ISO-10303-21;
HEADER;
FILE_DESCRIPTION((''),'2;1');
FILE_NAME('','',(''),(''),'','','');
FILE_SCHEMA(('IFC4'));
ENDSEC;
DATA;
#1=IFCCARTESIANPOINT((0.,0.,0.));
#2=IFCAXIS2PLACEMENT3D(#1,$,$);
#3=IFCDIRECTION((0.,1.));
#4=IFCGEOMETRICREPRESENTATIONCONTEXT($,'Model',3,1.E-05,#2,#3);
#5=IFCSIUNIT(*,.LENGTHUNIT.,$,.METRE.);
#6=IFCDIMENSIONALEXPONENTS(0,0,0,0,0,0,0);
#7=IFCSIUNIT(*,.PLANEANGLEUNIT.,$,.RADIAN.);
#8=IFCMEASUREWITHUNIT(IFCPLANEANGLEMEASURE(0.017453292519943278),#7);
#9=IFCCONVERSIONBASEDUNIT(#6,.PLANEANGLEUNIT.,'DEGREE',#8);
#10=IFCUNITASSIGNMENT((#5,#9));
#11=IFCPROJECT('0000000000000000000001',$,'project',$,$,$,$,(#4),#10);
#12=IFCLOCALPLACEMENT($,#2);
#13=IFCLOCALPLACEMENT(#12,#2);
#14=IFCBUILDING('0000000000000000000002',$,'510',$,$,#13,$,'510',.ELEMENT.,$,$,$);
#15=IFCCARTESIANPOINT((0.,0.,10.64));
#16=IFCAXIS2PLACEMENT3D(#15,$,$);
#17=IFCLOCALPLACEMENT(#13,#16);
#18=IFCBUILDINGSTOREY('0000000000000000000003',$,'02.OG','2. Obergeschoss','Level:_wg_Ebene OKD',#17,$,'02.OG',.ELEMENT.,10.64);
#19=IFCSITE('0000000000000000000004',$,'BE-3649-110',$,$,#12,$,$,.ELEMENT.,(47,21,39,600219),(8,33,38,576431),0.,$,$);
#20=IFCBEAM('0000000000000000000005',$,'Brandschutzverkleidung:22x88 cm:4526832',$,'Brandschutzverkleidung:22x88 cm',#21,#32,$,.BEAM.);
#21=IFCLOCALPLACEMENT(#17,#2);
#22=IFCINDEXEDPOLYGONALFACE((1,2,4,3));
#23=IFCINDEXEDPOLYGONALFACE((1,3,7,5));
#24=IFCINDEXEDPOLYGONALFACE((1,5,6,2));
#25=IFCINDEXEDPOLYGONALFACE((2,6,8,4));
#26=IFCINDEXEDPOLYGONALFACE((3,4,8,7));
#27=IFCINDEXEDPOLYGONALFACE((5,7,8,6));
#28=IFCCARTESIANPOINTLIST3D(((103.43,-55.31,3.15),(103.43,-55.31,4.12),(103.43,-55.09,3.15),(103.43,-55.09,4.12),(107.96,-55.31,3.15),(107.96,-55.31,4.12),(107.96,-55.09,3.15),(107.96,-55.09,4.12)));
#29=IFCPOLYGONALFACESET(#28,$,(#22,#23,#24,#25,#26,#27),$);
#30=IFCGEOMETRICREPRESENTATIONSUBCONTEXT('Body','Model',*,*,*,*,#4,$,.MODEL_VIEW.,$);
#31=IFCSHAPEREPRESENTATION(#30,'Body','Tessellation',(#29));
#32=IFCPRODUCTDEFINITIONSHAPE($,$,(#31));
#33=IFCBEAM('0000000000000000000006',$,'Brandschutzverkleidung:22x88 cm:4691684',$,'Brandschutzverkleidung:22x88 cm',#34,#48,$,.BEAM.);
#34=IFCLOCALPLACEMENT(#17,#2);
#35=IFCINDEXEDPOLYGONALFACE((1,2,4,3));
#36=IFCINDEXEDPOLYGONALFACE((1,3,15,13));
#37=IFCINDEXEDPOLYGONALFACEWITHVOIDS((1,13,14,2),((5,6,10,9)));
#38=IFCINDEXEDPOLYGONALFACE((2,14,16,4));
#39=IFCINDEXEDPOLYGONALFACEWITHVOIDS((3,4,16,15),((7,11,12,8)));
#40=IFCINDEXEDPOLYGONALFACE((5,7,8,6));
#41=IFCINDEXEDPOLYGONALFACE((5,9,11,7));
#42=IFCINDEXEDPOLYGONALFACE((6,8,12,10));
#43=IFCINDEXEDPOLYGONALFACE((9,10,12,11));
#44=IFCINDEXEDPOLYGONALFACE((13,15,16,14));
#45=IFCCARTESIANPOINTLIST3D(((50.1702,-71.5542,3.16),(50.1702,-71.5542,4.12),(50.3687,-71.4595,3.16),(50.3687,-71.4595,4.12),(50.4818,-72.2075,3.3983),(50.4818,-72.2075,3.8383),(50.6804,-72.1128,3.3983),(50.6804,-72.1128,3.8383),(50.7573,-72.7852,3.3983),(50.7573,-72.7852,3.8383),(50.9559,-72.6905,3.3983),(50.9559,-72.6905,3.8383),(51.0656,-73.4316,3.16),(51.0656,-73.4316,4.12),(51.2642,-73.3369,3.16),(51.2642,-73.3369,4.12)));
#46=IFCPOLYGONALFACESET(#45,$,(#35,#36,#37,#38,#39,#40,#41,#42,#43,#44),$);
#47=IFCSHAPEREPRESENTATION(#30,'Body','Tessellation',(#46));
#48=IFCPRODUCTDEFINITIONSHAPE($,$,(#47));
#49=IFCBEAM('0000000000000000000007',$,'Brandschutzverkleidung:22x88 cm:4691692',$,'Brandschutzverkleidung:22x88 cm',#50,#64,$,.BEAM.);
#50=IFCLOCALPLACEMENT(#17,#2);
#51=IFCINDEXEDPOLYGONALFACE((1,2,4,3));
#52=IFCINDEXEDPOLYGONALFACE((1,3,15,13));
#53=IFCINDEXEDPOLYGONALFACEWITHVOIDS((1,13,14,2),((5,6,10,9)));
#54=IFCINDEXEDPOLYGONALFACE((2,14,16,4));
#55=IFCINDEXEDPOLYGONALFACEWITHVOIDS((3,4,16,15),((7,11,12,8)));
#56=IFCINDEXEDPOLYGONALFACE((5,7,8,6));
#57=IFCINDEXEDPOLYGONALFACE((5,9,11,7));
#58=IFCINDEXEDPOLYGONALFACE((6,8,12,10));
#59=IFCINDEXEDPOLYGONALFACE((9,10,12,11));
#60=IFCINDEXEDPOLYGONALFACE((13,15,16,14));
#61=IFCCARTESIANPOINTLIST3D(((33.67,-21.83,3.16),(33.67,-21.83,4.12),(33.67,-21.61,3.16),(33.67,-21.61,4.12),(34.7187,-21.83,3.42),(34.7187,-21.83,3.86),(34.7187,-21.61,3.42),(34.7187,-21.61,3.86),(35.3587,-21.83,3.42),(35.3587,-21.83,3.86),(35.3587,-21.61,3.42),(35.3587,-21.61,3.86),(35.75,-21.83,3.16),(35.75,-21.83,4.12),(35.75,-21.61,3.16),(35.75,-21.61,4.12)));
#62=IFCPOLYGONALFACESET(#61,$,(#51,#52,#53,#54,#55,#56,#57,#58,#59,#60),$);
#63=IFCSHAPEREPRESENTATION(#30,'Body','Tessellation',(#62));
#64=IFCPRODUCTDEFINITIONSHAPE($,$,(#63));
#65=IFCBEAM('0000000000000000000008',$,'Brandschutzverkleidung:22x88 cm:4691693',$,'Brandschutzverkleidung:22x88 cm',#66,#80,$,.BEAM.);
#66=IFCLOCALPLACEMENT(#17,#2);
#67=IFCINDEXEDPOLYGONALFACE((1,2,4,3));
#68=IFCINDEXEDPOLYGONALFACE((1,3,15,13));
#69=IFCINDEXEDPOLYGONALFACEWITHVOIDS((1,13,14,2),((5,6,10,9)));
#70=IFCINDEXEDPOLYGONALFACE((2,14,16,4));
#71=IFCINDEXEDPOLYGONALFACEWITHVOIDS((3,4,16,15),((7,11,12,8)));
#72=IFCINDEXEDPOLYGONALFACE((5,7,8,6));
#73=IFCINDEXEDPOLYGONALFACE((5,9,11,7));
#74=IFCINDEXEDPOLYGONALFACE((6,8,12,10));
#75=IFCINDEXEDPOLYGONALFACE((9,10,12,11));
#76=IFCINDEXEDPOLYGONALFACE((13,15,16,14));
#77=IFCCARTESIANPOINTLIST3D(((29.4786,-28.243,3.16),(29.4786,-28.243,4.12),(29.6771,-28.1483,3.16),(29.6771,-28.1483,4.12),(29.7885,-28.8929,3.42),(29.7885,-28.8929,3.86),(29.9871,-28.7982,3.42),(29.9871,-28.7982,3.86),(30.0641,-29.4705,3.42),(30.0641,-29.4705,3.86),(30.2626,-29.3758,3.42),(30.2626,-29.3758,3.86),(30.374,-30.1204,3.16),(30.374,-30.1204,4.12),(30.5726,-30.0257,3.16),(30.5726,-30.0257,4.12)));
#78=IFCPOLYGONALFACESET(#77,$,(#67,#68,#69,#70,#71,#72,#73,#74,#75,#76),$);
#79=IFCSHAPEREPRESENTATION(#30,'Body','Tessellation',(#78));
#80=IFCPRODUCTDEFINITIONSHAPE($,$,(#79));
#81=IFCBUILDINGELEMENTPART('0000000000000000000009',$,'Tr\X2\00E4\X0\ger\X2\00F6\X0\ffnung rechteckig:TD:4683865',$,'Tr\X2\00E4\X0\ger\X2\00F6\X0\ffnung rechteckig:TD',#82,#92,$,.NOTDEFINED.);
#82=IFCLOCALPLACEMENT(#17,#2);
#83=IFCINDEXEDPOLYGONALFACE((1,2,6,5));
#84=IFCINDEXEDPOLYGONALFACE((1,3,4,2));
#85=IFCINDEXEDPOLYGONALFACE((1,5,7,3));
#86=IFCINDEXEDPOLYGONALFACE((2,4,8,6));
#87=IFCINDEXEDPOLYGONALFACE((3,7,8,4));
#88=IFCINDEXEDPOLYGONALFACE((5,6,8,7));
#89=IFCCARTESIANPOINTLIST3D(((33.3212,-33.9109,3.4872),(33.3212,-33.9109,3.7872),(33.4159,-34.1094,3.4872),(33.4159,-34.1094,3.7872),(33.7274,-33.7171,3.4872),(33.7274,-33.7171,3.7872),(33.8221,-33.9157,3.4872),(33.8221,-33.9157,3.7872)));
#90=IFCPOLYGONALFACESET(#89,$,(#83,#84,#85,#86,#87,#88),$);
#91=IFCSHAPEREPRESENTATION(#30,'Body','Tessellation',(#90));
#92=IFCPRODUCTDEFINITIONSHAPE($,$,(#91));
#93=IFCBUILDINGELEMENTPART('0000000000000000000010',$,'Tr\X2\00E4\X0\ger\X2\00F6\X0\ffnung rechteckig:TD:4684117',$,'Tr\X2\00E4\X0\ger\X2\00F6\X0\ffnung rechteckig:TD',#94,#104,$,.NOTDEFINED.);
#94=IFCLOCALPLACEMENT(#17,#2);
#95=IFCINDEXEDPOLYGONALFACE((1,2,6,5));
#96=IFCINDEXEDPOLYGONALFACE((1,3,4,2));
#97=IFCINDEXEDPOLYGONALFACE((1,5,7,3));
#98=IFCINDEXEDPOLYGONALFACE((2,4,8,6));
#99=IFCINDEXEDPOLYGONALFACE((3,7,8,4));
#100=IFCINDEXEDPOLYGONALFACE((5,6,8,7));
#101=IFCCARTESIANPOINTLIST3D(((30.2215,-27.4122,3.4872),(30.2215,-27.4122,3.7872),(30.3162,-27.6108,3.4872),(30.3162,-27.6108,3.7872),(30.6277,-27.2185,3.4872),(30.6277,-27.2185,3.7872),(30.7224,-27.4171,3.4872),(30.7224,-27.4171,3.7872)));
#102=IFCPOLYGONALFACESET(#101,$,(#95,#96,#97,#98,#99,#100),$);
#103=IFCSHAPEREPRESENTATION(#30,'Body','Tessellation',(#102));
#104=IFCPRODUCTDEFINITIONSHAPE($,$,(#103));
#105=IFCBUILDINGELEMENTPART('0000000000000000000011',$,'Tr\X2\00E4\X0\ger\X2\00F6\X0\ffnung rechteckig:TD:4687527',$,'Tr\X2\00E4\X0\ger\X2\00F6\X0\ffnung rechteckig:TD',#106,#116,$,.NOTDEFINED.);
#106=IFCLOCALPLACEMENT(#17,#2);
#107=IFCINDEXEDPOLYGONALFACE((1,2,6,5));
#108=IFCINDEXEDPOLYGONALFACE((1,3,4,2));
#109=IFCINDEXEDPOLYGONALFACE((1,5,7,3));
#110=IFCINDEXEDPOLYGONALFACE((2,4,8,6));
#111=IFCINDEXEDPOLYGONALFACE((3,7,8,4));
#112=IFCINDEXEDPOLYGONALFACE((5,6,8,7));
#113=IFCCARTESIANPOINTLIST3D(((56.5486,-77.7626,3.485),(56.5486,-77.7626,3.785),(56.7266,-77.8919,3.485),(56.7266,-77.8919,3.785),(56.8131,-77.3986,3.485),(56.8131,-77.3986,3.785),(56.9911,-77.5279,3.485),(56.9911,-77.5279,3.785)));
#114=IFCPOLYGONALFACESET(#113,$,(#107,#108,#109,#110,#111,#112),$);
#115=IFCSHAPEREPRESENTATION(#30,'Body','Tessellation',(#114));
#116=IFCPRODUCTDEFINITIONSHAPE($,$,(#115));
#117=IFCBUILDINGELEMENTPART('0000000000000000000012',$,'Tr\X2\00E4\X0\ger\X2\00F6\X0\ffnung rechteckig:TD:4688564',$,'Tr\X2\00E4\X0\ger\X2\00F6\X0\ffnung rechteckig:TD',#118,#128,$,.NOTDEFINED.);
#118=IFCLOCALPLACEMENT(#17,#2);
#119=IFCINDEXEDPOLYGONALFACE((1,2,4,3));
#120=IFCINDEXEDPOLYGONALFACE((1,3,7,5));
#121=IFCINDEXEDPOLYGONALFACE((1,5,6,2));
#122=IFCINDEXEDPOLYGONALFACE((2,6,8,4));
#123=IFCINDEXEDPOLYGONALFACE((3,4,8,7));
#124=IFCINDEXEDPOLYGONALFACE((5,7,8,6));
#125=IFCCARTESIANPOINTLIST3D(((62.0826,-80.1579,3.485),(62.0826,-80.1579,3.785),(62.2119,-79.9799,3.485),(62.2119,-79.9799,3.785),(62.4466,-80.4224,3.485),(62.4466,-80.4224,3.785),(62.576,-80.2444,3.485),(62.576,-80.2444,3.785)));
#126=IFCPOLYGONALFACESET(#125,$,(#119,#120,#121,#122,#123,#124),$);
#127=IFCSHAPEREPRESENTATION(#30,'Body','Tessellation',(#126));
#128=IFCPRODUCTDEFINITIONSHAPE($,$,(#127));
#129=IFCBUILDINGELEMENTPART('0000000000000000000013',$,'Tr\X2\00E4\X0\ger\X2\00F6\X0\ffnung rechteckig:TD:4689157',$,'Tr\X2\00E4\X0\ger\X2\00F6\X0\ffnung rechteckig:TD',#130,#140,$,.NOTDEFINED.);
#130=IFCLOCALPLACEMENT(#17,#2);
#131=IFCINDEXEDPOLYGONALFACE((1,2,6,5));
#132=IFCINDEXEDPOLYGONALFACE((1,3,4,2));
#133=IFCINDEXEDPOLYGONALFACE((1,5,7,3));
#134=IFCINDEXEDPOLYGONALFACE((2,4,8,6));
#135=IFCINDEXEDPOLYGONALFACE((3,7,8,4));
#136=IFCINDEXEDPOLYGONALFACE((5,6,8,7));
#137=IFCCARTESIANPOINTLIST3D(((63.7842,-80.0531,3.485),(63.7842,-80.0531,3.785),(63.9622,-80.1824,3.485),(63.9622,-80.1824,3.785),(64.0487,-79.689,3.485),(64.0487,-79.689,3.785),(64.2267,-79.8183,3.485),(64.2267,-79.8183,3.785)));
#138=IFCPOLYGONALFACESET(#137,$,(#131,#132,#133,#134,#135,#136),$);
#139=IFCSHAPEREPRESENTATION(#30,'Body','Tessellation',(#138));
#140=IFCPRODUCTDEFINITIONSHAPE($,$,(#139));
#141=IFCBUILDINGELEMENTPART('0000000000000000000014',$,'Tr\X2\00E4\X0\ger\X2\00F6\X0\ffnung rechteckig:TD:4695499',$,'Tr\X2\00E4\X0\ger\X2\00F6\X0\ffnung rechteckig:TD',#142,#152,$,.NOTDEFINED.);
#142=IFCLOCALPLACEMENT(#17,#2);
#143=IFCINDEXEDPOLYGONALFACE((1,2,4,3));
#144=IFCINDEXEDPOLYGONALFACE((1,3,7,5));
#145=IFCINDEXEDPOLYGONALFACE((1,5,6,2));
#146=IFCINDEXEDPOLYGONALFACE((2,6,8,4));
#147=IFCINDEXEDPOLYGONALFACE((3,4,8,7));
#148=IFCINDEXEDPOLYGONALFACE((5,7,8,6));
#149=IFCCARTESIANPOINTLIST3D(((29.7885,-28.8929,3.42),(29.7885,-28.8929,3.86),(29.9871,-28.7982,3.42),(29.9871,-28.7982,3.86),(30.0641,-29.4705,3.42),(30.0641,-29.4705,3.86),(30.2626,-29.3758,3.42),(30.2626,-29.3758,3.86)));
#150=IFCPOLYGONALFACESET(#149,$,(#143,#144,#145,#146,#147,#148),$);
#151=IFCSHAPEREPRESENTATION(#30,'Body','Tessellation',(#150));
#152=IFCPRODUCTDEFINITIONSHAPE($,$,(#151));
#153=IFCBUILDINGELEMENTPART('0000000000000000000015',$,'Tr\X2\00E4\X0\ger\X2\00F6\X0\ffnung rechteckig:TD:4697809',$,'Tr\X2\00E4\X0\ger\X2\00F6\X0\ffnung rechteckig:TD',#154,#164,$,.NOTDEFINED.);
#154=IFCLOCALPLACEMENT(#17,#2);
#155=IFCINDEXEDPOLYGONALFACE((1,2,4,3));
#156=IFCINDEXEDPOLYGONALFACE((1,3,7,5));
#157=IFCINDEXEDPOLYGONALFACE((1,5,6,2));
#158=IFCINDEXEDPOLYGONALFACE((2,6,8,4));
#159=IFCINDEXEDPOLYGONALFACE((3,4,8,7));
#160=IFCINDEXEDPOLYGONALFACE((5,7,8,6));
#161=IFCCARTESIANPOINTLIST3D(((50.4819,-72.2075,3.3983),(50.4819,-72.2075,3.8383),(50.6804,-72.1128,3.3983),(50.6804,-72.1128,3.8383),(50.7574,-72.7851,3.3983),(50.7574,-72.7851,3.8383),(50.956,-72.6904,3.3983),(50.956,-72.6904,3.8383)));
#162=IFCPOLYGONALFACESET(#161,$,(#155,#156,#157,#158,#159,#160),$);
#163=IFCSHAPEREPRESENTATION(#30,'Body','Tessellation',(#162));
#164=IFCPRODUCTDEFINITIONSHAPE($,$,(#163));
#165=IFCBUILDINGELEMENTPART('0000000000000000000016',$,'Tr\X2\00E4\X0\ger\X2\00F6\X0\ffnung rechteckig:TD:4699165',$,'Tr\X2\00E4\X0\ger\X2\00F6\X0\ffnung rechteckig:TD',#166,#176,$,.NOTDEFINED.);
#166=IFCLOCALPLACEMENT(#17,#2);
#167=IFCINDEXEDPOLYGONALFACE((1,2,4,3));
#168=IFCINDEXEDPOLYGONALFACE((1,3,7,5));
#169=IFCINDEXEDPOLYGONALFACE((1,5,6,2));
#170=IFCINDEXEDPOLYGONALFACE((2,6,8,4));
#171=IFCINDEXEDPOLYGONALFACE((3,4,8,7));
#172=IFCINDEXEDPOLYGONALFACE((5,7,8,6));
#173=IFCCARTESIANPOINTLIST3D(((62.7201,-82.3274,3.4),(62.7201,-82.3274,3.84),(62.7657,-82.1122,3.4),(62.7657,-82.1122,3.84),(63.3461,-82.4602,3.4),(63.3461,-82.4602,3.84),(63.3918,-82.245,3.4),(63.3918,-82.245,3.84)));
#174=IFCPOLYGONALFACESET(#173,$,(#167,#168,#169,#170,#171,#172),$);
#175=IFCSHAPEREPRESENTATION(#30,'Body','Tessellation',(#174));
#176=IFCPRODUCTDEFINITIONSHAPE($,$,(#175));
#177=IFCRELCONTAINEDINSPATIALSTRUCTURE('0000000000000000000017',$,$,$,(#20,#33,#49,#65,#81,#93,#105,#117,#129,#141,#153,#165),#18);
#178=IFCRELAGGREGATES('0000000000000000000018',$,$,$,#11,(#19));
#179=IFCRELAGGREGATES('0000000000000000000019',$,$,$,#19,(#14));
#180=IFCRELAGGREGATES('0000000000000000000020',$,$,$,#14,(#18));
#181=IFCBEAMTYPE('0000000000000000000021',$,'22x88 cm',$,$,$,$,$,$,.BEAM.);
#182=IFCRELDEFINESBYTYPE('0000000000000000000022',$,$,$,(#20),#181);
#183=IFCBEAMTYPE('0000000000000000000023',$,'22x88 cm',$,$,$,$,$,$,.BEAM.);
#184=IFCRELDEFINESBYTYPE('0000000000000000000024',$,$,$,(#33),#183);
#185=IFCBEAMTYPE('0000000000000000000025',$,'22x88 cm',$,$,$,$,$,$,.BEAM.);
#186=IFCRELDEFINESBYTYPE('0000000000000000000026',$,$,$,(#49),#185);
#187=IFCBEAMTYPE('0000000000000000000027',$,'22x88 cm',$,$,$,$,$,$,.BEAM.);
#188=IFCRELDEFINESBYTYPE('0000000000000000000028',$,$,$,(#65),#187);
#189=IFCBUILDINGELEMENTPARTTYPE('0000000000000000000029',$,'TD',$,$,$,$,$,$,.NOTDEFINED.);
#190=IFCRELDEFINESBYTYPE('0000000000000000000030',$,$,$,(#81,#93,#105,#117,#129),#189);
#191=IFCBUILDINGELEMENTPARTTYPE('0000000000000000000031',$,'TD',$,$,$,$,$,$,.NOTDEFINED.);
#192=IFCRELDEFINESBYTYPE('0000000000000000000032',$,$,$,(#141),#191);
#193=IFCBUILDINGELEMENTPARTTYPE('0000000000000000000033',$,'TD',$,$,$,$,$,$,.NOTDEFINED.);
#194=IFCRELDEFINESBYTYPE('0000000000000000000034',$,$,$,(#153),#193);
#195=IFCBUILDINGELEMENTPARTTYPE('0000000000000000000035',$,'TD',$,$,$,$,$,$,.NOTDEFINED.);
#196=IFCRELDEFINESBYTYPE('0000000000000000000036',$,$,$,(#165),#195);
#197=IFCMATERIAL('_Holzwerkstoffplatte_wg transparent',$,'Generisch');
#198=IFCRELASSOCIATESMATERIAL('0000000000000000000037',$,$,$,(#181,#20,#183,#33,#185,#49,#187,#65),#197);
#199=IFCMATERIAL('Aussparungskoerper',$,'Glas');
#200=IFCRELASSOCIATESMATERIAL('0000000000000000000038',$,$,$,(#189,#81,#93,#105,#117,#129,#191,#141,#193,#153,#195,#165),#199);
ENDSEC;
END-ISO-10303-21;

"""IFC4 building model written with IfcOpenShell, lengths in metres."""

from ifc_helpers import new_model, entity, si_unit, converted_unit, direction, frame, origin, place, context, subcontext, project, spatial, indexed_curve, outline, extrude, source, transform, mapped, material, type_object, type_shapes, element, save


model = new_model("IFC4")

# Units and contexts
model_context = context("Model", 3, precision=1e-05, world=origin(), true_north=direction((0.0, 1.0)))
body_context = subcontext(model_context, "Body", "Model", "MODEL_VIEW")
ifc_project = project(units=[si_unit("LENGTHUNIT", "METRE"), converted_unit("PLANEANGLEUNIT", "DEGREE", entity("IfcPlaneAngleMeasure", 0.017453292519943278), si_unit("PLANEANGLEUNIT", "RADIAN"), dimensions=[0, 0, 0, 0, 0, 0, 0])], contexts=[model_context])

# Site, building, storey
site_placement = place(None, origin())
site = spatial("IfcSite", under=ifc_project, at=site_placement, Name="BE-3649-110", CompositionType="ELEMENT", RefLatitude=(47, 21, 39, 600219), RefLongitude=(8, 33, 38, 576431), RefElevation=0.0)
building_placement = place(site_placement, origin())
building = spatial("IfcBuilding", under=site, at=building_placement, Name="510", LongName="510", CompositionType="ELEMENT")
storey_placement = place(building_placement, frame((0.0, 0.0, 10.64)))
storey = spatial("IfcBuildingStorey", under=building, at=storey_placement, Name="02.OG", Description="2. Obergeschoss", ObjectType="Level:_wg_Ebene OKD", LongName="02.OG", CompositionType="ELEMENT", Elevation=10.64)

# Shared definitions
ifc_material_1 = material(Name="_Holzwerkstoffplatte_wg transparent", Category="Generisch")

# Beam
beam_type_1 = type_object("IfcBeamType", Name="22x88 cm", PredefinedType="BEAM", material=ifc_material_1)
shared_shape_1 = source(origin(), body_context, "Body", "SweptSolid", [
    extrude(outline(indexed_curve([(-2.265, -0.11), (2.265, -0.11), (2.265, 0.11), (-2.265, 0.11), (-2.265, -0.11)], self_intersect=False)), frame((0.0, 0.0, -0.485)), (0.0, 0.0, 1.0), 0.97),
])
type_shapes(beam_type_1, [shared_shape_1])
beam_1_placement = place(storey_placement, frame((105.695, -55.2, 3.635)))
element("IfcBeam", 1, at=beam_1_placement, inside=storey, type_object=beam_type_1, material=ifc_material_1, Name="Brandschutzverkleidung:22x88 cm:4526832", ObjectType="Brandschutzverkleidung:22x88 cm", PredefinedType="BEAM", context=body_context, shape_type="MappedRepresentation", body=[
    mapped(shared_shape_1, transform((0.0, 0.0, 0.0), scale=1.0)),
])

# Beams
beam_type_2 = type_object("IfcBeamType", Name="22x88 cm", PredefinedType="BEAM", material=ifc_material_1)
shared_shape_2 = source(origin(), body_context, "Body", "SweptSolid", [
    extrude(outline(indexed_curve([(-1.04, -0.48), (1.04, -0.48), (1.04, 0.48), (-1.04, 0.48), (-1.04, -0.48)], self_intersect=False), holes=[indexed_curve([(0.3238, 0.2417), (0.3238, -0.1983), (-0.3162, -0.1983), (-0.3162, 0.2417), (0.3238, 0.2417)], self_intersect=False)]), frame((50.6179, -72.4929, 0.0), z_axis=(0.902585, 0.430511, 0.0), x_axis=(0.430511, -0.902585, 0.0)), (0.0, 0.0, 1.0), 0.22),
])
type_shapes(beam_type_2, [shared_shape_2])
beam_2_placement = place(storey_placement, frame((0.0, 0.0, 3.64)))
element("IfcBeam", 2, at=beam_2_placement, inside=storey, type_object=beam_type_2, material=ifc_material_1, Name="Brandschutzverkleidung:22x88 cm:4691684", ObjectType="Brandschutzverkleidung:22x88 cm", PredefinedType="BEAM", context=body_context, shape_type="MappedRepresentation", body=[
    mapped(shared_shape_2, transform((0.0, 0.0, 0.0), scale=1.0)),
])
beam_type_3 = type_object("IfcBeamType", Name="22x88 cm", PredefinedType="BEAM", material=ifc_material_1)
shared_shape_3 = source(origin(), body_context, "Body", "SweptSolid", [
    extrude(outline(indexed_curve([(-1.04, -0.48), (1.04, -0.48), (1.04, 0.48), (-1.04, 0.48), (-1.04, -0.48)], self_intersect=False), holes=[indexed_curve([(0.6487, 0.22), (0.6487, -0.22), (0.0087, -0.22), (0.0087, 0.22), (0.6487, 0.22)], self_intersect=False)]), frame((34.71, -21.83, 0.0), z_axis=(0.0, 1.0, 0.0), x_axis=(1.0, 0.0, 0.0)), (0.0, 0.0, 1.0), 0.22),
])
type_shapes(beam_type_3, [shared_shape_3])
beam_3_placement = place(storey_placement, frame((0.0, 0.0, 3.64)))
element("IfcBeam", 3, at=beam_3_placement, inside=storey, type_object=beam_type_3, material=ifc_material_1, Name="Brandschutzverkleidung:22x88 cm:4691692", ObjectType="Brandschutzverkleidung:22x88 cm", PredefinedType="BEAM", context=body_context, shape_type="MappedRepresentation", body=[
    mapped(shared_shape_3, transform((0.0, 0.0, 0.0), scale=1.0)),
])
beam_type_4 = type_object("IfcBeamType", Name="22x88 cm", PredefinedType="BEAM", material=ifc_material_1)
shared_shape_4 = source(origin(), body_context, "Body", "SweptSolid", [
    extrude(outline(indexed_curve([(-1.04, -0.48), (1.04, -0.48), (1.04, 0.48), (-1.04, 0.48), (-1.04, -0.48)], self_intersect=False), holes=[indexed_curve([(-0.32, -0.22), (-0.32, 0.22), (0.32, 0.22), (0.32, -0.22), (-0.32, -0.22)], self_intersect=False)]), frame((29.9263, -29.1817, 0.0), z_axis=(0.902585, 0.430511, 0.0), x_axis=(-0.430511, 0.902585, 0.0)), (0.0, 0.0, 1.0), 0.22),
])
type_shapes(beam_type_4, [shared_shape_4])
beam_4_placement = place(storey_placement, frame((0.0, 0.0, 3.64)))
element("IfcBeam", 4, at=beam_4_placement, inside=storey, type_object=beam_type_4, material=ifc_material_1, Name="Brandschutzverkleidung:22x88 cm:4691693", ObjectType="Brandschutzverkleidung:22x88 cm", PredefinedType="BEAM", context=body_context, shape_type="MappedRepresentation", body=[
    mapped(shared_shape_4, transform((0.0, 0.0, 0.0), scale=1.0)),
])

# Building element parts
ifc_material_2 = material(Name="Aussparungskoerper", Category="Glas")
building_element_part_type_1 = type_object("IfcBuildingElementPartType", Name="TD", PredefinedType="NOTDEFINED", material=ifc_material_2)
shared_shape_5 = source(origin(), body_context, "Body", "SweptSolid", [
    extrude(outline(indexed_curve([(-0.225, -0.15), (0.225, -0.15), (0.225, 0.15), (-0.225, 0.15), (-0.225, -0.15)], self_intersect=False)), frame((0.0, 0.0, -0.22), z_axis=(0.0, 0.0, 1.0), x_axis=(-1.0, 0.0, 0.0)), (0.0, 0.0, 1.0), 0.22),
])
type_shapes(building_element_part_type_1, [shared_shape_5])
for number, where, z_axis, x_axis, name in (
    (5, (33.619, -34.0126, 3.6372), (0.430511, -0.902585, 0.0), (-0.902585, -0.430511, 0.0), "Trägeröffnung rechteckig:TD:4683865"),
    (6, (30.5193, -27.5139, 3.6372), (0.430511, -0.902585, 0.0), (-0.902585, -0.430511, 0.0), "Trägeröffnung rechteckig:TD:4684117"),
    (7, (56.8588, -77.7099, 3.635), (0.809017, -0.587785, 0.0), (-0.587785, -0.809017, 0.0), "Trägeröffnung rechteckig:TD:4687527"),
    (8, (62.2646, -80.2901, 3.635), (-0.587785, -0.809017, 0.0), (0.809017, -0.587785, 0.0), "Trägeröffnung rechteckig:TD:4688564"),
    (9, (64.0944, -80.0003, 3.635), (0.809017, -0.587785, 0.0), (-0.587785, -0.809017, 0.0), "Trägeröffnung rechteckig:TD:4689157"),
):
    element("IfcBuildingElementPart", number, at=place(storey_placement, frame(where, z_axis=z_axis, x_axis=x_axis)), inside=storey, type_object=building_element_part_type_1, material=ifc_material_2, Name=name, ObjectType="Trägeröffnung rechteckig:TD", PredefinedType="NOTDEFINED", context=body_context, shape_type="MappedRepresentation", body=[
        mapped(shared_shape_5, transform((0.0, 0.0, 0.0), scale=1.0)),
    ])
building_element_part_type_2 = type_object("IfcBuildingElementPartType", Name="TD", PredefinedType="NOTDEFINED", material=ifc_material_2)
shared_shape_6 = source(origin(), body_context, "Body", "SweptSolid", [
    extrude(outline(indexed_curve([(-0.11, -0.32), (0.11, -0.32), (0.11, 0.32), (-0.11, 0.32), (-0.11, -0.32)], self_intersect=False)), frame((30.0256, -29.1344, -0.44), z_axis=(0.0, 0.0, 1.0), x_axis=(-0.902585, -0.430511, 0.0)), (0.0, 0.0, 1.0), 0.44),
])
type_shapes(building_element_part_type_2, [shared_shape_6])
building_element_part_1_placement = place(storey_placement, frame((0.0, 0.0, 3.86)))
element("IfcBuildingElementPart", 10, at=building_element_part_1_placement, inside=storey, type_object=building_element_part_type_2, material=ifc_material_2, Name="Trägeröffnung rechteckig:TD:4695499", ObjectType="Trägeröffnung rechteckig:TD", PredefinedType="NOTDEFINED", context=body_context, shape_type="MappedRepresentation", body=[
    mapped(shared_shape_6, transform((0.0, 0.0, 0.0), scale=1.0)),
])
building_element_part_type_3 = type_object("IfcBuildingElementPartType", Name="TD", PredefinedType="NOTDEFINED", material=ifc_material_2)
shared_shape_7 = source(origin(), body_context, "Body", "SweptSolid", [
    extrude(outline(indexed_curve([(-0.11, -0.32), (0.11, -0.32), (0.11, 0.32), (-0.11, 0.32), (-0.11, -0.32)], self_intersect=False)), frame((50.7189, -72.449, -0.44), z_axis=(0.0, 0.0, 1.0), x_axis=(0.902586, 0.43051, 0.0)), (0.0, 0.0, 1.0), 0.44),
])
type_shapes(building_element_part_type_3, [shared_shape_7])
building_element_part_2_placement = place(storey_placement, frame((0.0, 0.0, 3.8383)))
element("IfcBuildingElementPart", 11, at=building_element_part_2_placement, inside=storey, type_object=building_element_part_type_3, material=ifc_material_2, Name="Trägeröffnung rechteckig:TD:4697809", ObjectType="Trägeröffnung rechteckig:TD", PredefinedType="NOTDEFINED", context=body_context, shape_type="MappedRepresentation", body=[
    mapped(shared_shape_7, transform((0.0, 0.0, 0.0), scale=1.0)),
])
building_element_part_type_4 = type_object("IfcBuildingElementPartType", Name="TD", PredefinedType="NOTDEFINED", material=ifc_material_2)
shared_shape_8 = source(origin(), body_context, "Body", "SweptSolid", [
    extrude(outline(indexed_curve([(-0.22, -0.32), (0.22, -0.32), (0.22, 0.32), (-0.22, 0.32), (-0.22, -0.32)], self_intersect=False)), frame((0.0, 0.0, -0.22), z_axis=(0.0, 0.0, 1.0), x_axis=(0.0, 1.0, 0.0)), (0.0, 0.0, 1.0), 0.22),
])
type_shapes(building_element_part_type_4, [shared_shape_8])
building_element_part_3_placement = place(storey_placement, frame((63.0331, -82.3938, 3.62), z_axis=(-0.207566, -0.978221, 0.0), x_axis=(0.978221, -0.207566, 0.0)))
element("IfcBuildingElementPart", 12, at=building_element_part_3_placement, inside=storey, type_object=building_element_part_type_4, material=ifc_material_2, Name="Trägeröffnung rechteckig:TD:4699165", ObjectType="Trägeröffnung rechteckig:TD", PredefinedType="NOTDEFINED", context=body_context, shape_type="MappedRepresentation", body=[
    mapped(shared_shape_8, transform((0.0, 0.0, 0.0), scale=1.0)),
])

save(model, "model.ifc")
